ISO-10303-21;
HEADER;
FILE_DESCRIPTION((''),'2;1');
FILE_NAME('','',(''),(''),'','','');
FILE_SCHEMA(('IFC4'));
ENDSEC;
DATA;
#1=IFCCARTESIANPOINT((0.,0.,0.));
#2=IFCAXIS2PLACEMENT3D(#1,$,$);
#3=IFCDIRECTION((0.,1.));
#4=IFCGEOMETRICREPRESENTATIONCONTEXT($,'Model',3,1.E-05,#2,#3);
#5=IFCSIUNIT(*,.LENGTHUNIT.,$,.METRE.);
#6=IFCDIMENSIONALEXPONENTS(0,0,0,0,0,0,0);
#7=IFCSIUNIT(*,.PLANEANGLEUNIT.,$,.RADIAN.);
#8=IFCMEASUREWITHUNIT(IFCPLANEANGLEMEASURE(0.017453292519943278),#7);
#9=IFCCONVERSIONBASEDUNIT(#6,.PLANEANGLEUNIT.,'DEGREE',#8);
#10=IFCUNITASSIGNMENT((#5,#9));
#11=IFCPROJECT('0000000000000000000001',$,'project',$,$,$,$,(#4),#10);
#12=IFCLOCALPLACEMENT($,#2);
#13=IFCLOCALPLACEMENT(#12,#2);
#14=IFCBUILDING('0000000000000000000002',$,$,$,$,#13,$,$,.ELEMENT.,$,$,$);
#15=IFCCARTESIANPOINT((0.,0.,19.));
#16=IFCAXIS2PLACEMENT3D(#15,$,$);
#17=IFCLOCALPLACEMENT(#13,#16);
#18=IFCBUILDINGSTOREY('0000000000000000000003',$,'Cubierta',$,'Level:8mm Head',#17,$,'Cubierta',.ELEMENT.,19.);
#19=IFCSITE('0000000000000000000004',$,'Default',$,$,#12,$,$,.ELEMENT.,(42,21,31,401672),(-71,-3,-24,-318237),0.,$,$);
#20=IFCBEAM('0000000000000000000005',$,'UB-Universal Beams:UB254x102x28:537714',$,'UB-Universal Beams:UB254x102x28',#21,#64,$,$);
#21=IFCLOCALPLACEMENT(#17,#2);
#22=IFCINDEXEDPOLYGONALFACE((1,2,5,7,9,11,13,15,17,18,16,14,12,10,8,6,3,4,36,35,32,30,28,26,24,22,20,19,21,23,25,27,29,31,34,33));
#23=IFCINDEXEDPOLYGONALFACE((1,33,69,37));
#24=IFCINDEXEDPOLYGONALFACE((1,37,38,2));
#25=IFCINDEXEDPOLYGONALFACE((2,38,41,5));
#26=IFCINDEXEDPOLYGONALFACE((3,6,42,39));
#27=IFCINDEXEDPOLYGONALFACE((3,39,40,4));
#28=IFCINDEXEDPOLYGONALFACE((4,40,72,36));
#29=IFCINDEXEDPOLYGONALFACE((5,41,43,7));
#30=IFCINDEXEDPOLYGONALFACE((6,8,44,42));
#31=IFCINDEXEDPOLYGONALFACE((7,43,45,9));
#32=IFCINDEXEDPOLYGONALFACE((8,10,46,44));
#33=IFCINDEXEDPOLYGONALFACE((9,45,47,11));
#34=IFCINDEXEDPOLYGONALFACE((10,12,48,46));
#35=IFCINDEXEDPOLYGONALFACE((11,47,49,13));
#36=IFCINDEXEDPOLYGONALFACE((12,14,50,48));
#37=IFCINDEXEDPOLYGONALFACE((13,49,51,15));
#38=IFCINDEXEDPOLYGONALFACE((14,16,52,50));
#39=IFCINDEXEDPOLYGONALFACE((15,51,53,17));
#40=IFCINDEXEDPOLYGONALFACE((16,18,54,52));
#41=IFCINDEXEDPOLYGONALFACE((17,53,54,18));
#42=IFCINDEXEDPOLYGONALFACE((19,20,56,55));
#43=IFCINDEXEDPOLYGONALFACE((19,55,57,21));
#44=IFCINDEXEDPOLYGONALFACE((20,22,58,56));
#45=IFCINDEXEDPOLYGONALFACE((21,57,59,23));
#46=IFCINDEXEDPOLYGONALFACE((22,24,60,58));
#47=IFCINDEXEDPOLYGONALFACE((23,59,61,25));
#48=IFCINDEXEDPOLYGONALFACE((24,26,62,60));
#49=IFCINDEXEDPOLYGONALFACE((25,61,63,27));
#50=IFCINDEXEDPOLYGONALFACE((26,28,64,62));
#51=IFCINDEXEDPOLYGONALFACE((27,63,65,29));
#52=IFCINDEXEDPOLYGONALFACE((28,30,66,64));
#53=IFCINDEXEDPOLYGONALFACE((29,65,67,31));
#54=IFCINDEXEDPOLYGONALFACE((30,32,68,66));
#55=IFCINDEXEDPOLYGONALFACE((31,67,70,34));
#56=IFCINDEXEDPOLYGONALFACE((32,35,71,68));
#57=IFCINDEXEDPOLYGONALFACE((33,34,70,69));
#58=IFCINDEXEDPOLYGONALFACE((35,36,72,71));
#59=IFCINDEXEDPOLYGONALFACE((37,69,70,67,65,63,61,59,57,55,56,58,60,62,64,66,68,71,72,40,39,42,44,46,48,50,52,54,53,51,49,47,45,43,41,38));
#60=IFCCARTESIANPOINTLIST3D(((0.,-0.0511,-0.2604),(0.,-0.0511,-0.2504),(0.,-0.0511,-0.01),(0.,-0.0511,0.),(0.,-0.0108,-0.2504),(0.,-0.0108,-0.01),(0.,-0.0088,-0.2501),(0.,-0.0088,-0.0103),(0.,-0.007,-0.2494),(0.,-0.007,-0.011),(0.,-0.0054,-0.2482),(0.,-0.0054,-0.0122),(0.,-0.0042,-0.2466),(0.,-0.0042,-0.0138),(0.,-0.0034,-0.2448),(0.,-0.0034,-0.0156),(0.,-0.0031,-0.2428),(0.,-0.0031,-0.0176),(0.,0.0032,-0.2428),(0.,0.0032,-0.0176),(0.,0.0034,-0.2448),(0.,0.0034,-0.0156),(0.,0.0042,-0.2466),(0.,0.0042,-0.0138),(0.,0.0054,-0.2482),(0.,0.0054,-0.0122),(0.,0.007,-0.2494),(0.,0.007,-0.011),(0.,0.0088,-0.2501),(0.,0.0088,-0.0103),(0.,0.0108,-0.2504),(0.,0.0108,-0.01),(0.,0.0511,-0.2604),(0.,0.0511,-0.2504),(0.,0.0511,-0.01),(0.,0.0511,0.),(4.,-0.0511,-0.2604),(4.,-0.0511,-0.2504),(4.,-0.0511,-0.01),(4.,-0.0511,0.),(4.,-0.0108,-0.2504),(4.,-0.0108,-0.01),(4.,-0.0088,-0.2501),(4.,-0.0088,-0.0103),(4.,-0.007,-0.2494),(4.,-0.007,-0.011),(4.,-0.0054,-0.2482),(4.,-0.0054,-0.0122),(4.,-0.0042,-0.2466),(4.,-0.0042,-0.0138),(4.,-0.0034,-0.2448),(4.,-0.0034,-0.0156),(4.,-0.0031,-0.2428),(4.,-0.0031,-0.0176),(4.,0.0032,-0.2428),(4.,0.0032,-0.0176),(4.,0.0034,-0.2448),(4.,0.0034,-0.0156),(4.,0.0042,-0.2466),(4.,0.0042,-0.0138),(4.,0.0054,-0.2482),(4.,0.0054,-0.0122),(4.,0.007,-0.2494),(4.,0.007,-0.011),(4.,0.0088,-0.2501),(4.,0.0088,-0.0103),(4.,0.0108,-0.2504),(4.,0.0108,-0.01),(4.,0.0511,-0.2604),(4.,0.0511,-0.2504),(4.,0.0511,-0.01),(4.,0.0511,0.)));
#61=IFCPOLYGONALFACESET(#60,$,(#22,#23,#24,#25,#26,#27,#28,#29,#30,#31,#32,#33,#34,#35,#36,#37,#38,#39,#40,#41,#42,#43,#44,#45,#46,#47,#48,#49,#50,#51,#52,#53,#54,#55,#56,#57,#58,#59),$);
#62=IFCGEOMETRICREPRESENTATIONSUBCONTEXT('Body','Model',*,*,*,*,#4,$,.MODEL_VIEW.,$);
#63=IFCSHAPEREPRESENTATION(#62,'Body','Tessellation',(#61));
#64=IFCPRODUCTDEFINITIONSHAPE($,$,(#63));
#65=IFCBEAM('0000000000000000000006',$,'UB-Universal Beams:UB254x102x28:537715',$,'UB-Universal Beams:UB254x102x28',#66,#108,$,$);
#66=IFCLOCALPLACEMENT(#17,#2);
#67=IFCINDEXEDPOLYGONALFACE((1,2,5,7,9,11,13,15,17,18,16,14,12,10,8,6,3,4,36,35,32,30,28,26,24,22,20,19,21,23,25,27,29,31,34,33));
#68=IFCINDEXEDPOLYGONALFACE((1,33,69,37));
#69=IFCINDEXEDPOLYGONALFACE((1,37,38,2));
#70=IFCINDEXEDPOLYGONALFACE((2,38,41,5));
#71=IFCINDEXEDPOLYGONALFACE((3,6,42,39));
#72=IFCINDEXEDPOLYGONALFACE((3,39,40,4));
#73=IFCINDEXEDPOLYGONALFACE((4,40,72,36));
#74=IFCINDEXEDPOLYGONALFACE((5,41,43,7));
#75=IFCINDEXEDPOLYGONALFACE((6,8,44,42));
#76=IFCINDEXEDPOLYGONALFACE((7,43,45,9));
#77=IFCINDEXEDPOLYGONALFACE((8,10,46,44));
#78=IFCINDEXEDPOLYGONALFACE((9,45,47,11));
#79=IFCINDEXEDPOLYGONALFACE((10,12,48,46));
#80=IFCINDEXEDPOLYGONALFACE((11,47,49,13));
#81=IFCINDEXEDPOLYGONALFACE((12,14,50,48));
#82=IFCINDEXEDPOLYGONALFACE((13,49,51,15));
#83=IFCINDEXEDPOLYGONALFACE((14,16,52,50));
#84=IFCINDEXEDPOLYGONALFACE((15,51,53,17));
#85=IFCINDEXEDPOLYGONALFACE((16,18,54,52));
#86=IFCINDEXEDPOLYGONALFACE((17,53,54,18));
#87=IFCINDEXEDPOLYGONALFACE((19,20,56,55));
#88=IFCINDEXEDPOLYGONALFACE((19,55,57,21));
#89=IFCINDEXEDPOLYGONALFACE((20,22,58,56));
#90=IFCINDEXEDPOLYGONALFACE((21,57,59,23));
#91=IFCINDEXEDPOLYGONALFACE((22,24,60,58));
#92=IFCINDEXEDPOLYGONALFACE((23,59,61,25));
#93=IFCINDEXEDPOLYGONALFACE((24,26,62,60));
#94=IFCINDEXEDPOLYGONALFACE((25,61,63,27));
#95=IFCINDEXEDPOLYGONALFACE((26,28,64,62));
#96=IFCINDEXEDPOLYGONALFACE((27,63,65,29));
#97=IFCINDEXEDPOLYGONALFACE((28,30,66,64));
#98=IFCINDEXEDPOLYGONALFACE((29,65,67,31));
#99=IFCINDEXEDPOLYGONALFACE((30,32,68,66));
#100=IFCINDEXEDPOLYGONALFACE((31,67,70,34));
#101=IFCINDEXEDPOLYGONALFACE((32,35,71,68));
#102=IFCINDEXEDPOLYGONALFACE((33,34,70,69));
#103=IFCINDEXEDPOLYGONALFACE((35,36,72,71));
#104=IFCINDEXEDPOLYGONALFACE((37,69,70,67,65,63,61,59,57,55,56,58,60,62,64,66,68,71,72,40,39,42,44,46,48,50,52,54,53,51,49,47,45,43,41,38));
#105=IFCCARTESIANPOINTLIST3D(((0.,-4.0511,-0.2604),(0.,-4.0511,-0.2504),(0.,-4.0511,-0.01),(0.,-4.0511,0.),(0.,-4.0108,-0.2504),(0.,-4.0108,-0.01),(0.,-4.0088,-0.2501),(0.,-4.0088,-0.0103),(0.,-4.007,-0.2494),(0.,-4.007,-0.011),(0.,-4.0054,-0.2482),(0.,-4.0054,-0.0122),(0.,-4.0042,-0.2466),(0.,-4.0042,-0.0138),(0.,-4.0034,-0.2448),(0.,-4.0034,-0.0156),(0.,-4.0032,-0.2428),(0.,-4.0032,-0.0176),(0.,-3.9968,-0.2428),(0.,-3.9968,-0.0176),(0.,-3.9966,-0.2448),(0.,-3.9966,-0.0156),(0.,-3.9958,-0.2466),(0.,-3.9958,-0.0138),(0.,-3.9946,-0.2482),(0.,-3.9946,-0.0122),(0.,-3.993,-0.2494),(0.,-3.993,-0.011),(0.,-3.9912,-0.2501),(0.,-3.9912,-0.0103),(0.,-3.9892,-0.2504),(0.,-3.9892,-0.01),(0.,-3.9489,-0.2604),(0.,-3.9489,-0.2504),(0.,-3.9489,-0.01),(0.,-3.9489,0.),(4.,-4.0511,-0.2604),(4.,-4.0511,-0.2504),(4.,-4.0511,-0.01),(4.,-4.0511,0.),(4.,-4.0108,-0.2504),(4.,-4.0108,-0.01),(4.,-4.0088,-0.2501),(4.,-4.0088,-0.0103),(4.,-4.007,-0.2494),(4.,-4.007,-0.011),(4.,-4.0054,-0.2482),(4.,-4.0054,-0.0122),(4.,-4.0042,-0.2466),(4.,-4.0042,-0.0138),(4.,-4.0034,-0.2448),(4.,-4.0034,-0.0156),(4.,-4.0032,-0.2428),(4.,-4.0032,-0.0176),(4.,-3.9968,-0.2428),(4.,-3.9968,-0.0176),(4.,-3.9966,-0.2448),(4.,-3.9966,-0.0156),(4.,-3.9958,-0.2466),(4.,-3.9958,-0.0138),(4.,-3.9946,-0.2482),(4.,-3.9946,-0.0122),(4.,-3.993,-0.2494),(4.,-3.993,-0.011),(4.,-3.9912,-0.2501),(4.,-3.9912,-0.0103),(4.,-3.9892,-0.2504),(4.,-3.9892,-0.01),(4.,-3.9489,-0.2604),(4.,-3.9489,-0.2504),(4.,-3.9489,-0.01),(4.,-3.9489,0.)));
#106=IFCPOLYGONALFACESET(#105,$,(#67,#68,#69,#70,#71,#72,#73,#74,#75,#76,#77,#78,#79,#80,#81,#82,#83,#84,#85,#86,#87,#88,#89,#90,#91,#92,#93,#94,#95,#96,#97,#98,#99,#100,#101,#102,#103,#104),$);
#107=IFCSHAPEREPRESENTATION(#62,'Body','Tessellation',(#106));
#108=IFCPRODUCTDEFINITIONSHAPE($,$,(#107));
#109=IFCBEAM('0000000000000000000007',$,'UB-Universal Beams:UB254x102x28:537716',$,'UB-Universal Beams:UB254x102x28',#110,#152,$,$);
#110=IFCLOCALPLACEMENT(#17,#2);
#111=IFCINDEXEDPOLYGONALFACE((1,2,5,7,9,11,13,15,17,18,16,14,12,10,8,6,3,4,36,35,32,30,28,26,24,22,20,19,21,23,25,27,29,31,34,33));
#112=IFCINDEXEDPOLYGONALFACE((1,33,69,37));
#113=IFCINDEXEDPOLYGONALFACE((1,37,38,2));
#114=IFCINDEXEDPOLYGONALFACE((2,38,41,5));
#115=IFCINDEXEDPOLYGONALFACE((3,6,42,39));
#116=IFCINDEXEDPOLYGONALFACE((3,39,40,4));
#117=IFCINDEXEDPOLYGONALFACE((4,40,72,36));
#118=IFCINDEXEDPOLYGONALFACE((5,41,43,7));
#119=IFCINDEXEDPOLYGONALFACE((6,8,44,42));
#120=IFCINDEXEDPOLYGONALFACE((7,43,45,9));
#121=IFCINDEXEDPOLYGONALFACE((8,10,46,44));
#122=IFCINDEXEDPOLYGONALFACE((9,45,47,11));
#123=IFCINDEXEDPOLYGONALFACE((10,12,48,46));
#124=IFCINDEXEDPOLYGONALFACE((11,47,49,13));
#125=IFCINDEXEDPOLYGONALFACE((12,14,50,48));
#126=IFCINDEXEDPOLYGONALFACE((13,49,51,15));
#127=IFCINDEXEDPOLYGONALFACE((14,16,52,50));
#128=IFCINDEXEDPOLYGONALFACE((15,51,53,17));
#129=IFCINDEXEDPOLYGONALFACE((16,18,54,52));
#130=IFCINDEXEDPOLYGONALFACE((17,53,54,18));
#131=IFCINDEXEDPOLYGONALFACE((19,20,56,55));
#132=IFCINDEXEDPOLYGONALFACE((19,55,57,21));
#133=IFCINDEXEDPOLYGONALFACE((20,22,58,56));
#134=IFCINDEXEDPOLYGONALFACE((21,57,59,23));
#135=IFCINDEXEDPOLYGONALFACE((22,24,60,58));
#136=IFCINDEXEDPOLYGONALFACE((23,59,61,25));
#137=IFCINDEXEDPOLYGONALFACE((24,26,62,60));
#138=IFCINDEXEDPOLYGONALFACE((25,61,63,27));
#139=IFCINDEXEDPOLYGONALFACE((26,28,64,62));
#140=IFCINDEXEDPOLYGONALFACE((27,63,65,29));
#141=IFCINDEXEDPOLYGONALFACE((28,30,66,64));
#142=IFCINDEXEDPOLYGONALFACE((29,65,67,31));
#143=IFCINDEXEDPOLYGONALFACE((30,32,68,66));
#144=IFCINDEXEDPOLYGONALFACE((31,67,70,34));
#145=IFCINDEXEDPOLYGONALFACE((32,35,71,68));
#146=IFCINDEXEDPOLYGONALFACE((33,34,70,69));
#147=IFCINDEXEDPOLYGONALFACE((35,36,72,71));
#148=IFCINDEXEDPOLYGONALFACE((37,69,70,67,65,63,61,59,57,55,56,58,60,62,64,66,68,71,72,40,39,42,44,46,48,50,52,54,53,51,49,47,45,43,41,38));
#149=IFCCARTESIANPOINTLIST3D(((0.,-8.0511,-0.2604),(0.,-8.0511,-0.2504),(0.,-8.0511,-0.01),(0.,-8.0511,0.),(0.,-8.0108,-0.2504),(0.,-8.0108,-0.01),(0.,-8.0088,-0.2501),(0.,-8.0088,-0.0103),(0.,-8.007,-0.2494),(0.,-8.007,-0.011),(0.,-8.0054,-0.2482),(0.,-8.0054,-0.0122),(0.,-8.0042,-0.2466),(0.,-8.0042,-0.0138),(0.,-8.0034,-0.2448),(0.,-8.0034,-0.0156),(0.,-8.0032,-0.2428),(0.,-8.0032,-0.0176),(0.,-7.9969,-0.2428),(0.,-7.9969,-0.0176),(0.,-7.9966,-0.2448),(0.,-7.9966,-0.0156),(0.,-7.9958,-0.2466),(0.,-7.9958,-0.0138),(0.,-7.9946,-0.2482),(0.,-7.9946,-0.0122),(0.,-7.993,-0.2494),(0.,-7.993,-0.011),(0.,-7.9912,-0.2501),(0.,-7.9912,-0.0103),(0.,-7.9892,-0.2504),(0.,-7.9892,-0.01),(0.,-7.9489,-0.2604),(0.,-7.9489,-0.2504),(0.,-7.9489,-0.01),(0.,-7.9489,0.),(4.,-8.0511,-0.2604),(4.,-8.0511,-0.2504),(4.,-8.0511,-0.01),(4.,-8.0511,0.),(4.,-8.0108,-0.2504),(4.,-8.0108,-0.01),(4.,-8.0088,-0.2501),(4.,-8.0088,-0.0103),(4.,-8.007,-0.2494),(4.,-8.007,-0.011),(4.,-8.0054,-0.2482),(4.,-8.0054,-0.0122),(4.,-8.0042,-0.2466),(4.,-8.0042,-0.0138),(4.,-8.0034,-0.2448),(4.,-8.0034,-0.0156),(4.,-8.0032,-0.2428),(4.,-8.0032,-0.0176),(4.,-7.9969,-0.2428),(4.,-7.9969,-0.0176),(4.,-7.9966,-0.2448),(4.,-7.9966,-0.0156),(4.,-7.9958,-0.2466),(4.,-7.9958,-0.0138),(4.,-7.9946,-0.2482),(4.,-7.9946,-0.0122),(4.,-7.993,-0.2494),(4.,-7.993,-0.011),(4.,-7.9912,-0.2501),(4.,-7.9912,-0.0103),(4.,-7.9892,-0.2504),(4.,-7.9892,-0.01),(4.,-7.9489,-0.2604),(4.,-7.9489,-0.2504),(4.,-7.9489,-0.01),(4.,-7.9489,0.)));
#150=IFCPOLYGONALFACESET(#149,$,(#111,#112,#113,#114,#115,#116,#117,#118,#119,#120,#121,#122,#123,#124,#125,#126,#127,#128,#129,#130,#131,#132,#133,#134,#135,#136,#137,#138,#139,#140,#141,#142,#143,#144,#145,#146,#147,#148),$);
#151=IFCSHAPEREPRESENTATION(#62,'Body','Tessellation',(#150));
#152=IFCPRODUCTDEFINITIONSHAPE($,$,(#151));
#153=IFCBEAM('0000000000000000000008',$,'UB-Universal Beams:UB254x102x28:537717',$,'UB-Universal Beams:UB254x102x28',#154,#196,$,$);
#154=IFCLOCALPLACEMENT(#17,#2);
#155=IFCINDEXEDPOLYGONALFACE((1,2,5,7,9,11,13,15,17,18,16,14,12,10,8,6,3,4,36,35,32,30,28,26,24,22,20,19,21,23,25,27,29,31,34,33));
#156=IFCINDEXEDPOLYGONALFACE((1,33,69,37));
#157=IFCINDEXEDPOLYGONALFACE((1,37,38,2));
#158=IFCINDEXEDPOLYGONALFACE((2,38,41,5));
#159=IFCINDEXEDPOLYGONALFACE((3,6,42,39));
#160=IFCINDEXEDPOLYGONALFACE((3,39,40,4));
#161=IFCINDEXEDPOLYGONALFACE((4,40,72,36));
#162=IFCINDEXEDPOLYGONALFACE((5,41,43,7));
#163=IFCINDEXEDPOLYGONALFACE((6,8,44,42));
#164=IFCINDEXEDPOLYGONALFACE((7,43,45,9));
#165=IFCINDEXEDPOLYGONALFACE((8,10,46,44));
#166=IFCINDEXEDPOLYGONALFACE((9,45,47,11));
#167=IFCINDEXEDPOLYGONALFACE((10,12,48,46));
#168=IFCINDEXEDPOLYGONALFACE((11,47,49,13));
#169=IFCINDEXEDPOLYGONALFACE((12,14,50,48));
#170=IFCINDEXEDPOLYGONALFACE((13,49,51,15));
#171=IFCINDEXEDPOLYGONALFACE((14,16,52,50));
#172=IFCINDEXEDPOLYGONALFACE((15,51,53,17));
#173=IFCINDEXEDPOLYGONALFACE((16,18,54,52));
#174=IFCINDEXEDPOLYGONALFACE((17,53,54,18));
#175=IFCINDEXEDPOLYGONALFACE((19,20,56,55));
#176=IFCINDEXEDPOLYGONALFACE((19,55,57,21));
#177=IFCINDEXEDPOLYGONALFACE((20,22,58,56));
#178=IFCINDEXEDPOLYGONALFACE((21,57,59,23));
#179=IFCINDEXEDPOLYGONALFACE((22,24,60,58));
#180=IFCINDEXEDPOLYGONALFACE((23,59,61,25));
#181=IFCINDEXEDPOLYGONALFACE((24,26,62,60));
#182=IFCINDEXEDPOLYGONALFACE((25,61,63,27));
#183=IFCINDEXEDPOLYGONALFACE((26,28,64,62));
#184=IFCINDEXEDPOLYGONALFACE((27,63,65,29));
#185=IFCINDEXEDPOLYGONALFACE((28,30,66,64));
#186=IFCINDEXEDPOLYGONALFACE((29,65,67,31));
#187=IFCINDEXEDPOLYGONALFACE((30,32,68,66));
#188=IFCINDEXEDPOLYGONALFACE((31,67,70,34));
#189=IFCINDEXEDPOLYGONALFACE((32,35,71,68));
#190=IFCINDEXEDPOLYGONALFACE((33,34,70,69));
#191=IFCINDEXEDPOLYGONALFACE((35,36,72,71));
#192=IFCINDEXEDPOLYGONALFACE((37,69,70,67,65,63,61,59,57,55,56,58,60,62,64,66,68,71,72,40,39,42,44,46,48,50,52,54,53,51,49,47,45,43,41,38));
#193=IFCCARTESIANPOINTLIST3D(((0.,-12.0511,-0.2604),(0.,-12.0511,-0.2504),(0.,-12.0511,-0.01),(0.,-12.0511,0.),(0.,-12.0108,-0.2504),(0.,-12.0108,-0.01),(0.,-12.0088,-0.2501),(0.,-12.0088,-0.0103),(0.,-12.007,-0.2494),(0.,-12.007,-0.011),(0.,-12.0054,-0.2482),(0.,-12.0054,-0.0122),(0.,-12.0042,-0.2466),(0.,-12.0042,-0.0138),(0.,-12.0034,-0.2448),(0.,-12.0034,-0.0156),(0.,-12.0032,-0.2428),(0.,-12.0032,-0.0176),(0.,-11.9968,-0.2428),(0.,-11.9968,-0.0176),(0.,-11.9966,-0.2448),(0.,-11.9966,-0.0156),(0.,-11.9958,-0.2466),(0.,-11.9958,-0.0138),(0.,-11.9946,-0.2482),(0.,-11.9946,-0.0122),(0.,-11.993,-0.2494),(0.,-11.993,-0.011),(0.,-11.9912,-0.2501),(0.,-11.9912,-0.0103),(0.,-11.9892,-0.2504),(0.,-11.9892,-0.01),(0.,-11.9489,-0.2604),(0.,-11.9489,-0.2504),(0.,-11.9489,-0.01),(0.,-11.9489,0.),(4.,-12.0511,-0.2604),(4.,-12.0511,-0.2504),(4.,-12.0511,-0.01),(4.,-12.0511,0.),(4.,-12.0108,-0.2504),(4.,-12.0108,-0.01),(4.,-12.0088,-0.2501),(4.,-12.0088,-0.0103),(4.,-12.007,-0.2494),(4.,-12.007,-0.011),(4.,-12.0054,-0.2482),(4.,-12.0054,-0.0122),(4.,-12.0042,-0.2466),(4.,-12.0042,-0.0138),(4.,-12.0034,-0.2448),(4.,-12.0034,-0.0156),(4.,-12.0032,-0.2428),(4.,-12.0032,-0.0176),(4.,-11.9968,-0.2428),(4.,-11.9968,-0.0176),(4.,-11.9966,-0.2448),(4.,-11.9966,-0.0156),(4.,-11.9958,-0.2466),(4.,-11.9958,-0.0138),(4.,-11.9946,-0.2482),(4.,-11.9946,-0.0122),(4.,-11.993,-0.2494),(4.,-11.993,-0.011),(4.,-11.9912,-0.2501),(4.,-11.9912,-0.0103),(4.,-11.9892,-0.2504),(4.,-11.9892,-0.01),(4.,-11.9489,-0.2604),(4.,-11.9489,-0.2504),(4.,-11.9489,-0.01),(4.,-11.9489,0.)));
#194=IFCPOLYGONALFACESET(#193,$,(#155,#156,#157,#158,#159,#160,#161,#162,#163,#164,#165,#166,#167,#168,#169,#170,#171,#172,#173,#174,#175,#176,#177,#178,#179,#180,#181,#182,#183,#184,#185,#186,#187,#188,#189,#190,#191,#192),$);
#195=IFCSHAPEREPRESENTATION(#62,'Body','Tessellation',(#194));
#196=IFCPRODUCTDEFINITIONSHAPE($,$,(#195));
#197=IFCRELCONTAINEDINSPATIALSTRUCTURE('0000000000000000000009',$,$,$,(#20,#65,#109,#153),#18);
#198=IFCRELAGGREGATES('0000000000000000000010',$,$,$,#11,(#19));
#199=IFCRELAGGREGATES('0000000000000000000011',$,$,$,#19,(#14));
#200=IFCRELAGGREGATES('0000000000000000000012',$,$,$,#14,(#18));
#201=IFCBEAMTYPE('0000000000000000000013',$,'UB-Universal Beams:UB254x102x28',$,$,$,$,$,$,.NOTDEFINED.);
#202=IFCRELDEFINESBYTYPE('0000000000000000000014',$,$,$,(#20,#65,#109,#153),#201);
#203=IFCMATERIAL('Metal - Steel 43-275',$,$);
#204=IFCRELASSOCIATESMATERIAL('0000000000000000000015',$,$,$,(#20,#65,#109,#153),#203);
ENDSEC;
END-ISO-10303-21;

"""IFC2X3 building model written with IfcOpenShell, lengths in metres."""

from ifc_helpers import new_model, entity, si_unit, converted_unit, direction, frame, frame_2d, origin, place, context, subcontext, project, spatial, i_section, extrude, material, type_object, element, save


model = new_model("IFC2X3")

# Units and contexts
model_context = context("Model", 3, precision=1e-05, world=origin(), true_north=direction((0.0, 1.0)))
body_context = subcontext(model_context, "Body", "Model", "MODEL_VIEW")
ifc_project = project(units=[si_unit("LENGTHUNIT", "METRE"), converted_unit("PLANEANGLEUNIT", "DEGREE", entity("IfcPlaneAngleMeasure", 0.017453292519943278), si_unit("PLANEANGLEUNIT", "RADIAN"), dimensions=[0, 0, 0, 0, 0, 0, 0])], contexts=[model_context])

# Site, building, storey
site_placement = place(None, origin())
site = spatial("IfcSite", under=ifc_project, at=site_placement, Name="Default", CompositionType="ELEMENT", RefLatitude=(42, 21, 31, 401672), RefLongitude=(-71, -3, -24, -318237), RefElevation=0.0)
building_placement = place(site_placement, origin())
building = spatial("IfcBuilding", under=site, at=building_placement, CompositionType="ELEMENT")
storey_placement = place(building_placement, frame((0.0, 0.0, 19.0)))
storey = spatial("IfcBuildingStorey", under=building, at=storey_placement, Name="Cubierta", ObjectType="Level:8mm Head", LongName="Cubierta", CompositionType="ELEMENT", Elevation=19.0)

# Beams
ifc_material = material(Name="Metal - Steel 43-275")
beam_type = type_object("IfcBeamType", Name="UB-Universal Beams:UB254x102x28", PredefinedType="NOTDEFINED")
beam_1_placement = place(storey_placement, origin())
element("IfcBeam", 1, at=beam_1_placement, inside=storey, type_object=beam_type, material=ifc_material, Name="UB-Universal Beams:UB254x102x28:537714", ObjectType="UB-Universal Beams:UB254x102x28", context=body_context, shape_type="SweptSolid", body=[
    extrude(i_section(OverallWidth=0.1022, OverallDepth=0.2604, WebThickness=0.0063, FlangeThickness=0.01, FilletRadius=0.0076, at=frame_2d((0.0, 0.0), x_axis=(0.0, 1.0))), frame((0.0, 0.0, -0.1302), z_axis=(1.0, 0.0, 0.0), x_axis=(0.0, 0.0, -1.0)), (0.0, 0.0, 1.0), 4.0),
])
beam_2_placement = place(storey_placement, frame((0.0, -4.0, 0.0)))
element("IfcBeam", 2, at=beam_2_placement, inside=storey, type_object=beam_type, material=ifc_material, Name="UB-Universal Beams:UB254x102x28:537715", ObjectType="UB-Universal Beams:UB254x102x28", context=body_context, shape_type="SweptSolid", body=[
    extrude(i_section(OverallWidth=0.1022, OverallDepth=0.2604, WebThickness=0.0063, FlangeThickness=0.01, FilletRadius=0.0076, at=frame_2d((0.0, 0.0), x_axis=(0.0, 1.0))), frame((0.0, 0.0, -0.1302), z_axis=(1.0, 0.0, 0.0), x_axis=(0.0, 0.0, -1.0)), (0.0, 0.0, 1.0), 4.0),
])
beam_3_placement = place(storey_placement, frame((0.0, -8.0, 0.0)))
element("IfcBeam", 3, at=beam_3_placement, inside=storey, type_object=beam_type, material=ifc_material, Name="UB-Universal Beams:UB254x102x28:537716", ObjectType="UB-Universal Beams:UB254x102x28", context=body_context, shape_type="SweptSolid", body=[
    extrude(i_section(OverallWidth=0.1022, OverallDepth=0.2604, WebThickness=0.0063, FlangeThickness=0.01, FilletRadius=0.0076, at=frame_2d((0.0, 0.0), x_axis=(0.0, 1.0))), frame((0.0, 0.0, -0.1302), z_axis=(1.0, 0.0, 0.0), x_axis=(0.0, 0.0, -1.0)), (0.0, 0.0, 1.0), 4.0),
])
beam_4_placement = place(storey_placement, frame((0.0, -12.0, 0.0)))
element("IfcBeam", 4, at=beam_4_placement, inside=storey, type_object=beam_type, material=ifc_material, Name="UB-Universal Beams:UB254x102x28:537717", ObjectType="UB-Universal Beams:UB254x102x28", context=body_context, shape_type="SweptSolid", body=[
    extrude(i_section(OverallWidth=0.1022, OverallDepth=0.2604, WebThickness=0.0063, FlangeThickness=0.01, FilletRadius=0.0076, at=frame_2d((0.0, 0.0), x_axis=(0.0, 1.0))), frame((0.0, 0.0, -0.1302), z_axis=(1.0, 0.0, 0.0), x_axis=(0.0, 0.0, -1.0)), (0.0, 0.0, 1.0), 4.0),
])

save(model, "model.ifc")
